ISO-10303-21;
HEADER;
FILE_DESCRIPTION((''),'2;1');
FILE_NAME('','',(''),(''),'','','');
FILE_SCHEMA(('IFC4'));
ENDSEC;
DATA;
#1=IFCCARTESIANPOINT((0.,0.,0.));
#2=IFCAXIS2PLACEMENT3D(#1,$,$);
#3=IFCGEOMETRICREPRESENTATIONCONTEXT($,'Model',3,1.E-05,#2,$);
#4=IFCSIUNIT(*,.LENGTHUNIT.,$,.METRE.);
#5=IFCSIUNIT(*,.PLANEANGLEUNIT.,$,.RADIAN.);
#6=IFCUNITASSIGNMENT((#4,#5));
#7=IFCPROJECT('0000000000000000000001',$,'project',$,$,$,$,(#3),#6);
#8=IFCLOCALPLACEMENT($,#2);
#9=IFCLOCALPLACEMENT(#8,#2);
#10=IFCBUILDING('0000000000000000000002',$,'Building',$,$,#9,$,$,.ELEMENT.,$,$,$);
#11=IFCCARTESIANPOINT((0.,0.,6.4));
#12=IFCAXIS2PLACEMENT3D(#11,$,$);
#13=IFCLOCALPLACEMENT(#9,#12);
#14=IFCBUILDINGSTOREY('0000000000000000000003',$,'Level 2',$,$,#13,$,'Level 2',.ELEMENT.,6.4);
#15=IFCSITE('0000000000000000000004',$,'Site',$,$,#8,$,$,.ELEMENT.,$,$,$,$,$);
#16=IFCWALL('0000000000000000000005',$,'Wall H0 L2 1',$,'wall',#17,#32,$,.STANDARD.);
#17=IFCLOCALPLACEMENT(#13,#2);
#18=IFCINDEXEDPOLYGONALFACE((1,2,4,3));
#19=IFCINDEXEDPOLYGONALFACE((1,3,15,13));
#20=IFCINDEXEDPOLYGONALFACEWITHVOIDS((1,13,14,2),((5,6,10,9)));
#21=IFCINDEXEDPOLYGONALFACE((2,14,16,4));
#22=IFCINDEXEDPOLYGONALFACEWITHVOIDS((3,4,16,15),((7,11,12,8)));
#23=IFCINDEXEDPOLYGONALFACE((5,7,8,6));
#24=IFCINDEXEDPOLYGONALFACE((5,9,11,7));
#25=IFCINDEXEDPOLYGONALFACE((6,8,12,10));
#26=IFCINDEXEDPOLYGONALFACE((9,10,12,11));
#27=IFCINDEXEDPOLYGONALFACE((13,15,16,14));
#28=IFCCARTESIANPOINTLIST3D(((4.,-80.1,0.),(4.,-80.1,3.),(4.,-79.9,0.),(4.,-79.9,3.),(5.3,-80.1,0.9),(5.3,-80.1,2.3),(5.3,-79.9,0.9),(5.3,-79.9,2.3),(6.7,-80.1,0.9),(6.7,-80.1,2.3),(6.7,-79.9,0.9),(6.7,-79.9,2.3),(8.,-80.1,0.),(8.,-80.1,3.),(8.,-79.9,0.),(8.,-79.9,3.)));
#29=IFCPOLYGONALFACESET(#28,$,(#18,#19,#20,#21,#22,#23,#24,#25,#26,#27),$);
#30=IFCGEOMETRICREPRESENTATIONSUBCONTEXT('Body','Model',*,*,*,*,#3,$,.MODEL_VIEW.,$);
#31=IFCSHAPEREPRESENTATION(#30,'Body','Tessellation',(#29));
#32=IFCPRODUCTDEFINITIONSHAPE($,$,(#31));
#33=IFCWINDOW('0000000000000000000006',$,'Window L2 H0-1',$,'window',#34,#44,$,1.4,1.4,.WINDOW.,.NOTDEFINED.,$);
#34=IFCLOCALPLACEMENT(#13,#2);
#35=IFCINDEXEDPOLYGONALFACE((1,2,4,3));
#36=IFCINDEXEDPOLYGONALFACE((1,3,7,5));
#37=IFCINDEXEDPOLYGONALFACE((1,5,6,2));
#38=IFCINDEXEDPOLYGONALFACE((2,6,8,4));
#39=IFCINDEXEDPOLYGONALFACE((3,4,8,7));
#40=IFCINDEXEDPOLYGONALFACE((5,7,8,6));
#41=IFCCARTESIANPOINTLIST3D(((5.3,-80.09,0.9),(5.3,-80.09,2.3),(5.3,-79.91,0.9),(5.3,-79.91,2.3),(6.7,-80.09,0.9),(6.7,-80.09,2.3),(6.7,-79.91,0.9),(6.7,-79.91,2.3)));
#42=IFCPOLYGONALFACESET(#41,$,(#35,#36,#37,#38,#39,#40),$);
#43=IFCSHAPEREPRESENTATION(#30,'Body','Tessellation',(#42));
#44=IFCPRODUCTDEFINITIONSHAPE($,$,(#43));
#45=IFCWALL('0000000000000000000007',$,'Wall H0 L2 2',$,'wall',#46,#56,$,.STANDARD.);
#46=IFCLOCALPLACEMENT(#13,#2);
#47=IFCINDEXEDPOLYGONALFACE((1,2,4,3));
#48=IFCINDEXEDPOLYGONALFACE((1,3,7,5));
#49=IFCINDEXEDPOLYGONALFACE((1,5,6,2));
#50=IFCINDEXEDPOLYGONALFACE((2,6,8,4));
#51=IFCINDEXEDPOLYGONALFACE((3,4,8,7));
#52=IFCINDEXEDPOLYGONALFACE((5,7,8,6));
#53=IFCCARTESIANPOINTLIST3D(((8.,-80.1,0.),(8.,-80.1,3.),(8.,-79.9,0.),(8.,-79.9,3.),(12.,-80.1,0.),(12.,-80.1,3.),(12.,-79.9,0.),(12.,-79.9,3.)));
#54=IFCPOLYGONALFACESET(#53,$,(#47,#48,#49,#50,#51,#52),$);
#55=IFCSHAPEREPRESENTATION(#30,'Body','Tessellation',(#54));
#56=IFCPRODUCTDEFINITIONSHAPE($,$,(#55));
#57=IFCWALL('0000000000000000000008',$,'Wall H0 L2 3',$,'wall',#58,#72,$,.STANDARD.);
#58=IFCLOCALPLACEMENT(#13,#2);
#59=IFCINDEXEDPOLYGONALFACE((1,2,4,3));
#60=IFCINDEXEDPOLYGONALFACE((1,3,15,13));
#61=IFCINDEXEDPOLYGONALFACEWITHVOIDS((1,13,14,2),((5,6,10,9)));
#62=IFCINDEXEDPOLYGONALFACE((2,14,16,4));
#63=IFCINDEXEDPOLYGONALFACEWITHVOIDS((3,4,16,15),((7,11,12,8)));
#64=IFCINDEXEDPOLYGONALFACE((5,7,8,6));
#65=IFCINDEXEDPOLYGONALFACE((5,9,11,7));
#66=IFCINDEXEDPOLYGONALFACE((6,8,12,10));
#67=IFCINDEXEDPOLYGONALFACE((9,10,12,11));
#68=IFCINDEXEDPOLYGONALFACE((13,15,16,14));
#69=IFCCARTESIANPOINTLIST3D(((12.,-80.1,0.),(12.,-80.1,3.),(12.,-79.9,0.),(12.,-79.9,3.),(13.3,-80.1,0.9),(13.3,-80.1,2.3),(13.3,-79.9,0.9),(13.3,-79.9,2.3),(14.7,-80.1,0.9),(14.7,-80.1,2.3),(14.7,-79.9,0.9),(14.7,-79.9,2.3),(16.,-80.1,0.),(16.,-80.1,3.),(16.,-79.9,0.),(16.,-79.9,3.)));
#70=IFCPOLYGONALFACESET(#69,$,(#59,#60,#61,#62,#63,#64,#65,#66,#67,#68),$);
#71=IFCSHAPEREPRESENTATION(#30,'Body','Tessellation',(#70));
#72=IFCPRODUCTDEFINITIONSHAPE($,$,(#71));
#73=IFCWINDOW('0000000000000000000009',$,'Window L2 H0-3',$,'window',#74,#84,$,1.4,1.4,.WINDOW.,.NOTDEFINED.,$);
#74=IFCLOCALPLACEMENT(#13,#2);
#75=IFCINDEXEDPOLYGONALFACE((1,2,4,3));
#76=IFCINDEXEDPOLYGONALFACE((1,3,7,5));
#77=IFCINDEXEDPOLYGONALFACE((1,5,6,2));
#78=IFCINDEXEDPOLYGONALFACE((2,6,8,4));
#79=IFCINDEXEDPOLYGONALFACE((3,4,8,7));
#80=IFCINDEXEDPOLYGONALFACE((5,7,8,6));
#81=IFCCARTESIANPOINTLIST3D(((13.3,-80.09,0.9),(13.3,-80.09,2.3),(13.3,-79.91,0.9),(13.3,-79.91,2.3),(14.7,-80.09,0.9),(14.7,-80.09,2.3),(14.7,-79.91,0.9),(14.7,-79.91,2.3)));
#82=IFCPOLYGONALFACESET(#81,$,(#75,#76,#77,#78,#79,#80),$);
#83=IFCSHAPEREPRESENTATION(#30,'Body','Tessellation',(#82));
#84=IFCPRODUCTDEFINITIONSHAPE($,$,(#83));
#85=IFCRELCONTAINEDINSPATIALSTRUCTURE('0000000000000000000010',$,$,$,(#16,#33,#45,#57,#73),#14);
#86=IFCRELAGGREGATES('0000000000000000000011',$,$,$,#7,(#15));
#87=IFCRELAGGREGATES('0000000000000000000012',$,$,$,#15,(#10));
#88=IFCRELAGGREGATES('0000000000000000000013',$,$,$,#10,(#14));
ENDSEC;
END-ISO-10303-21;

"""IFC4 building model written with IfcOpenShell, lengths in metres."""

from ifc_helpers import new_model, si_unit, frame, frame_2d, origin, origin_2d, place, context, subcontext, project, spatial, rectangle, extrude, element, fill, save


model = new_model("IFC4")

# Units and contexts
model_context = context("Model", 3, precision=1e-05, world=origin())
body_context = subcontext(model_context, "Body", "Model", "MODEL_VIEW")
ifc_project = project(units=[si_unit("LENGTHUNIT", "METRE"), si_unit("PLANEANGLEUNIT", "RADIAN")], contexts=[model_context])

# Site, building, storey
site_placement = place(None, origin())
site = spatial("IfcSite", under=ifc_project, at=site_placement, Name="Site", CompositionType="ELEMENT")
building_placement = place(site_placement, origin())
building = spatial("IfcBuilding", under=site, at=building_placement, Name="Building", CompositionType="ELEMENT")
storey_placement = place(building_placement, frame((0.0, 0.0, 6.4)))
storey = spatial("IfcBuildingStorey", under=building, at=storey_placement, Name="Level 2", LongName="Level 2", CompositionType="ELEMENT", Elevation=6.4)

# Wall, opening, window
wall_1_placement = place(storey_placement, frame((4.0, -80.0, 0.0), z_axis=(0.0, 0.0, 1.0), x_axis=(1.0, 0.0, 0.0)))
wall_1 = element("IfcWall", 1, at=wall_1_placement, inside=storey, Name="Wall H0 L2 1", ObjectType="wall", PredefinedType="STANDARD", context=body_context, shape_type="SweptSolid", body=[
    extrude(rectangle(XDim=4.0, YDim=0.2, at=frame_2d((2.0, 0.0))), origin(), (0.0, 0.0, 1.0), 3.0),
])
opening_1_placement = place(storey_placement, frame((6.0, -80.0, 0.9), z_axis=(0.0, 0.0, 1.0), x_axis=(1.0, 0.0, 0.0)))
opening_1 = element("IfcOpeningElement", 2, at=opening_1_placement, cuts=wall_1, ObjectType="Opening", PredefinedType="OPENING", context=body_context, shape_type="SweptSolid", body=[
    extrude(rectangle(XDim=1.4, YDim=0.22, at=origin_2d()), origin(), (0.0, 0.0, 1.0), 1.4),
])
window_1_placement = place(storey_placement, frame((6.0, -80.0, 0.9), z_axis=(0.0, 0.0, 1.0), x_axis=(1.0, 0.0, 0.0)))
window_1 = element("IfcWindow", 3, at=window_1_placement, inside=storey, Name="Window L2 H0-1", ObjectType="window", OverallHeight=1.4, OverallWidth=1.4, PartitioningType="NOTDEFINED", PredefinedType="WINDOW", context=body_context, shape_type="SweptSolid", body=[
    extrude(rectangle(XDim=1.4, YDim=0.18, at=origin_2d()), origin(), (0.0, 0.0, 1.0), 1.4),
])
fill(opening_1, window_1)

# Wall
wall_2_placement = place(storey_placement, frame((8.0, -80.0, 0.0), z_axis=(0.0, 0.0, 1.0), x_axis=(1.0, 0.0, 0.0)))
element("IfcWall", 4, at=wall_2_placement, inside=storey, Name="Wall H0 L2 2", ObjectType="wall", PredefinedType="STANDARD", context=body_context, shape_type="SweptSolid", body=[
    extrude(rectangle(XDim=4.0, YDim=0.2, at=frame_2d((2.0, 0.0))), origin(), (0.0, 0.0, 1.0), 3.0),
])

# Wall, opening, window
wall_3_placement = place(storey_placement, frame((12.0, -80.0, 0.0), z_axis=(0.0, 0.0, 1.0), x_axis=(1.0, 0.0, 0.0)))
wall_3 = element("IfcWall", 5, at=wall_3_placement, inside=storey, Name="Wall H0 L2 3", ObjectType="wall", PredefinedType="STANDARD", context=body_context, shape_type="SweptSolid", body=[
    extrude(rectangle(XDim=4.0, YDim=0.2, at=frame_2d((2.0, 0.0))), origin(), (0.0, 0.0, 1.0), 3.0),
])
opening_2_placement = place(storey_placement, frame((14.0, -80.0, 0.9), z_axis=(0.0, 0.0, 1.0), x_axis=(1.0, 0.0, 0.0)))
opening_2 = element("IfcOpeningElement", 6, at=opening_2_placement, cuts=wall_3, ObjectType="Opening", PredefinedType="OPENING", context=body_context, shape_type="SweptSolid", body=[
    extrude(rectangle(XDim=1.4, YDim=0.22, at=origin_2d()), origin(), (0.0, 0.0, 1.0), 1.4),
])
window_2_placement = place(storey_placement, frame((14.0, -80.0, 0.9), z_axis=(0.0, 0.0, 1.0), x_axis=(1.0, 0.0, 0.0)))
window_2 = element("IfcWindow", 7, at=window_2_placement, inside=storey, Name="Window L2 H0-3", ObjectType="window", OverallHeight=1.4, OverallWidth=1.4, PartitioningType="NOTDEFINED", PredefinedType="WINDOW", context=body_context, shape_type="SweptSolid", body=[
    extrude(rectangle(XDim=1.4, YDim=0.18, at=origin_2d()), origin(), (0.0, 0.0, 1.0), 1.4),
])
fill(opening_2, window_2)

save(model, "model.ifc")
